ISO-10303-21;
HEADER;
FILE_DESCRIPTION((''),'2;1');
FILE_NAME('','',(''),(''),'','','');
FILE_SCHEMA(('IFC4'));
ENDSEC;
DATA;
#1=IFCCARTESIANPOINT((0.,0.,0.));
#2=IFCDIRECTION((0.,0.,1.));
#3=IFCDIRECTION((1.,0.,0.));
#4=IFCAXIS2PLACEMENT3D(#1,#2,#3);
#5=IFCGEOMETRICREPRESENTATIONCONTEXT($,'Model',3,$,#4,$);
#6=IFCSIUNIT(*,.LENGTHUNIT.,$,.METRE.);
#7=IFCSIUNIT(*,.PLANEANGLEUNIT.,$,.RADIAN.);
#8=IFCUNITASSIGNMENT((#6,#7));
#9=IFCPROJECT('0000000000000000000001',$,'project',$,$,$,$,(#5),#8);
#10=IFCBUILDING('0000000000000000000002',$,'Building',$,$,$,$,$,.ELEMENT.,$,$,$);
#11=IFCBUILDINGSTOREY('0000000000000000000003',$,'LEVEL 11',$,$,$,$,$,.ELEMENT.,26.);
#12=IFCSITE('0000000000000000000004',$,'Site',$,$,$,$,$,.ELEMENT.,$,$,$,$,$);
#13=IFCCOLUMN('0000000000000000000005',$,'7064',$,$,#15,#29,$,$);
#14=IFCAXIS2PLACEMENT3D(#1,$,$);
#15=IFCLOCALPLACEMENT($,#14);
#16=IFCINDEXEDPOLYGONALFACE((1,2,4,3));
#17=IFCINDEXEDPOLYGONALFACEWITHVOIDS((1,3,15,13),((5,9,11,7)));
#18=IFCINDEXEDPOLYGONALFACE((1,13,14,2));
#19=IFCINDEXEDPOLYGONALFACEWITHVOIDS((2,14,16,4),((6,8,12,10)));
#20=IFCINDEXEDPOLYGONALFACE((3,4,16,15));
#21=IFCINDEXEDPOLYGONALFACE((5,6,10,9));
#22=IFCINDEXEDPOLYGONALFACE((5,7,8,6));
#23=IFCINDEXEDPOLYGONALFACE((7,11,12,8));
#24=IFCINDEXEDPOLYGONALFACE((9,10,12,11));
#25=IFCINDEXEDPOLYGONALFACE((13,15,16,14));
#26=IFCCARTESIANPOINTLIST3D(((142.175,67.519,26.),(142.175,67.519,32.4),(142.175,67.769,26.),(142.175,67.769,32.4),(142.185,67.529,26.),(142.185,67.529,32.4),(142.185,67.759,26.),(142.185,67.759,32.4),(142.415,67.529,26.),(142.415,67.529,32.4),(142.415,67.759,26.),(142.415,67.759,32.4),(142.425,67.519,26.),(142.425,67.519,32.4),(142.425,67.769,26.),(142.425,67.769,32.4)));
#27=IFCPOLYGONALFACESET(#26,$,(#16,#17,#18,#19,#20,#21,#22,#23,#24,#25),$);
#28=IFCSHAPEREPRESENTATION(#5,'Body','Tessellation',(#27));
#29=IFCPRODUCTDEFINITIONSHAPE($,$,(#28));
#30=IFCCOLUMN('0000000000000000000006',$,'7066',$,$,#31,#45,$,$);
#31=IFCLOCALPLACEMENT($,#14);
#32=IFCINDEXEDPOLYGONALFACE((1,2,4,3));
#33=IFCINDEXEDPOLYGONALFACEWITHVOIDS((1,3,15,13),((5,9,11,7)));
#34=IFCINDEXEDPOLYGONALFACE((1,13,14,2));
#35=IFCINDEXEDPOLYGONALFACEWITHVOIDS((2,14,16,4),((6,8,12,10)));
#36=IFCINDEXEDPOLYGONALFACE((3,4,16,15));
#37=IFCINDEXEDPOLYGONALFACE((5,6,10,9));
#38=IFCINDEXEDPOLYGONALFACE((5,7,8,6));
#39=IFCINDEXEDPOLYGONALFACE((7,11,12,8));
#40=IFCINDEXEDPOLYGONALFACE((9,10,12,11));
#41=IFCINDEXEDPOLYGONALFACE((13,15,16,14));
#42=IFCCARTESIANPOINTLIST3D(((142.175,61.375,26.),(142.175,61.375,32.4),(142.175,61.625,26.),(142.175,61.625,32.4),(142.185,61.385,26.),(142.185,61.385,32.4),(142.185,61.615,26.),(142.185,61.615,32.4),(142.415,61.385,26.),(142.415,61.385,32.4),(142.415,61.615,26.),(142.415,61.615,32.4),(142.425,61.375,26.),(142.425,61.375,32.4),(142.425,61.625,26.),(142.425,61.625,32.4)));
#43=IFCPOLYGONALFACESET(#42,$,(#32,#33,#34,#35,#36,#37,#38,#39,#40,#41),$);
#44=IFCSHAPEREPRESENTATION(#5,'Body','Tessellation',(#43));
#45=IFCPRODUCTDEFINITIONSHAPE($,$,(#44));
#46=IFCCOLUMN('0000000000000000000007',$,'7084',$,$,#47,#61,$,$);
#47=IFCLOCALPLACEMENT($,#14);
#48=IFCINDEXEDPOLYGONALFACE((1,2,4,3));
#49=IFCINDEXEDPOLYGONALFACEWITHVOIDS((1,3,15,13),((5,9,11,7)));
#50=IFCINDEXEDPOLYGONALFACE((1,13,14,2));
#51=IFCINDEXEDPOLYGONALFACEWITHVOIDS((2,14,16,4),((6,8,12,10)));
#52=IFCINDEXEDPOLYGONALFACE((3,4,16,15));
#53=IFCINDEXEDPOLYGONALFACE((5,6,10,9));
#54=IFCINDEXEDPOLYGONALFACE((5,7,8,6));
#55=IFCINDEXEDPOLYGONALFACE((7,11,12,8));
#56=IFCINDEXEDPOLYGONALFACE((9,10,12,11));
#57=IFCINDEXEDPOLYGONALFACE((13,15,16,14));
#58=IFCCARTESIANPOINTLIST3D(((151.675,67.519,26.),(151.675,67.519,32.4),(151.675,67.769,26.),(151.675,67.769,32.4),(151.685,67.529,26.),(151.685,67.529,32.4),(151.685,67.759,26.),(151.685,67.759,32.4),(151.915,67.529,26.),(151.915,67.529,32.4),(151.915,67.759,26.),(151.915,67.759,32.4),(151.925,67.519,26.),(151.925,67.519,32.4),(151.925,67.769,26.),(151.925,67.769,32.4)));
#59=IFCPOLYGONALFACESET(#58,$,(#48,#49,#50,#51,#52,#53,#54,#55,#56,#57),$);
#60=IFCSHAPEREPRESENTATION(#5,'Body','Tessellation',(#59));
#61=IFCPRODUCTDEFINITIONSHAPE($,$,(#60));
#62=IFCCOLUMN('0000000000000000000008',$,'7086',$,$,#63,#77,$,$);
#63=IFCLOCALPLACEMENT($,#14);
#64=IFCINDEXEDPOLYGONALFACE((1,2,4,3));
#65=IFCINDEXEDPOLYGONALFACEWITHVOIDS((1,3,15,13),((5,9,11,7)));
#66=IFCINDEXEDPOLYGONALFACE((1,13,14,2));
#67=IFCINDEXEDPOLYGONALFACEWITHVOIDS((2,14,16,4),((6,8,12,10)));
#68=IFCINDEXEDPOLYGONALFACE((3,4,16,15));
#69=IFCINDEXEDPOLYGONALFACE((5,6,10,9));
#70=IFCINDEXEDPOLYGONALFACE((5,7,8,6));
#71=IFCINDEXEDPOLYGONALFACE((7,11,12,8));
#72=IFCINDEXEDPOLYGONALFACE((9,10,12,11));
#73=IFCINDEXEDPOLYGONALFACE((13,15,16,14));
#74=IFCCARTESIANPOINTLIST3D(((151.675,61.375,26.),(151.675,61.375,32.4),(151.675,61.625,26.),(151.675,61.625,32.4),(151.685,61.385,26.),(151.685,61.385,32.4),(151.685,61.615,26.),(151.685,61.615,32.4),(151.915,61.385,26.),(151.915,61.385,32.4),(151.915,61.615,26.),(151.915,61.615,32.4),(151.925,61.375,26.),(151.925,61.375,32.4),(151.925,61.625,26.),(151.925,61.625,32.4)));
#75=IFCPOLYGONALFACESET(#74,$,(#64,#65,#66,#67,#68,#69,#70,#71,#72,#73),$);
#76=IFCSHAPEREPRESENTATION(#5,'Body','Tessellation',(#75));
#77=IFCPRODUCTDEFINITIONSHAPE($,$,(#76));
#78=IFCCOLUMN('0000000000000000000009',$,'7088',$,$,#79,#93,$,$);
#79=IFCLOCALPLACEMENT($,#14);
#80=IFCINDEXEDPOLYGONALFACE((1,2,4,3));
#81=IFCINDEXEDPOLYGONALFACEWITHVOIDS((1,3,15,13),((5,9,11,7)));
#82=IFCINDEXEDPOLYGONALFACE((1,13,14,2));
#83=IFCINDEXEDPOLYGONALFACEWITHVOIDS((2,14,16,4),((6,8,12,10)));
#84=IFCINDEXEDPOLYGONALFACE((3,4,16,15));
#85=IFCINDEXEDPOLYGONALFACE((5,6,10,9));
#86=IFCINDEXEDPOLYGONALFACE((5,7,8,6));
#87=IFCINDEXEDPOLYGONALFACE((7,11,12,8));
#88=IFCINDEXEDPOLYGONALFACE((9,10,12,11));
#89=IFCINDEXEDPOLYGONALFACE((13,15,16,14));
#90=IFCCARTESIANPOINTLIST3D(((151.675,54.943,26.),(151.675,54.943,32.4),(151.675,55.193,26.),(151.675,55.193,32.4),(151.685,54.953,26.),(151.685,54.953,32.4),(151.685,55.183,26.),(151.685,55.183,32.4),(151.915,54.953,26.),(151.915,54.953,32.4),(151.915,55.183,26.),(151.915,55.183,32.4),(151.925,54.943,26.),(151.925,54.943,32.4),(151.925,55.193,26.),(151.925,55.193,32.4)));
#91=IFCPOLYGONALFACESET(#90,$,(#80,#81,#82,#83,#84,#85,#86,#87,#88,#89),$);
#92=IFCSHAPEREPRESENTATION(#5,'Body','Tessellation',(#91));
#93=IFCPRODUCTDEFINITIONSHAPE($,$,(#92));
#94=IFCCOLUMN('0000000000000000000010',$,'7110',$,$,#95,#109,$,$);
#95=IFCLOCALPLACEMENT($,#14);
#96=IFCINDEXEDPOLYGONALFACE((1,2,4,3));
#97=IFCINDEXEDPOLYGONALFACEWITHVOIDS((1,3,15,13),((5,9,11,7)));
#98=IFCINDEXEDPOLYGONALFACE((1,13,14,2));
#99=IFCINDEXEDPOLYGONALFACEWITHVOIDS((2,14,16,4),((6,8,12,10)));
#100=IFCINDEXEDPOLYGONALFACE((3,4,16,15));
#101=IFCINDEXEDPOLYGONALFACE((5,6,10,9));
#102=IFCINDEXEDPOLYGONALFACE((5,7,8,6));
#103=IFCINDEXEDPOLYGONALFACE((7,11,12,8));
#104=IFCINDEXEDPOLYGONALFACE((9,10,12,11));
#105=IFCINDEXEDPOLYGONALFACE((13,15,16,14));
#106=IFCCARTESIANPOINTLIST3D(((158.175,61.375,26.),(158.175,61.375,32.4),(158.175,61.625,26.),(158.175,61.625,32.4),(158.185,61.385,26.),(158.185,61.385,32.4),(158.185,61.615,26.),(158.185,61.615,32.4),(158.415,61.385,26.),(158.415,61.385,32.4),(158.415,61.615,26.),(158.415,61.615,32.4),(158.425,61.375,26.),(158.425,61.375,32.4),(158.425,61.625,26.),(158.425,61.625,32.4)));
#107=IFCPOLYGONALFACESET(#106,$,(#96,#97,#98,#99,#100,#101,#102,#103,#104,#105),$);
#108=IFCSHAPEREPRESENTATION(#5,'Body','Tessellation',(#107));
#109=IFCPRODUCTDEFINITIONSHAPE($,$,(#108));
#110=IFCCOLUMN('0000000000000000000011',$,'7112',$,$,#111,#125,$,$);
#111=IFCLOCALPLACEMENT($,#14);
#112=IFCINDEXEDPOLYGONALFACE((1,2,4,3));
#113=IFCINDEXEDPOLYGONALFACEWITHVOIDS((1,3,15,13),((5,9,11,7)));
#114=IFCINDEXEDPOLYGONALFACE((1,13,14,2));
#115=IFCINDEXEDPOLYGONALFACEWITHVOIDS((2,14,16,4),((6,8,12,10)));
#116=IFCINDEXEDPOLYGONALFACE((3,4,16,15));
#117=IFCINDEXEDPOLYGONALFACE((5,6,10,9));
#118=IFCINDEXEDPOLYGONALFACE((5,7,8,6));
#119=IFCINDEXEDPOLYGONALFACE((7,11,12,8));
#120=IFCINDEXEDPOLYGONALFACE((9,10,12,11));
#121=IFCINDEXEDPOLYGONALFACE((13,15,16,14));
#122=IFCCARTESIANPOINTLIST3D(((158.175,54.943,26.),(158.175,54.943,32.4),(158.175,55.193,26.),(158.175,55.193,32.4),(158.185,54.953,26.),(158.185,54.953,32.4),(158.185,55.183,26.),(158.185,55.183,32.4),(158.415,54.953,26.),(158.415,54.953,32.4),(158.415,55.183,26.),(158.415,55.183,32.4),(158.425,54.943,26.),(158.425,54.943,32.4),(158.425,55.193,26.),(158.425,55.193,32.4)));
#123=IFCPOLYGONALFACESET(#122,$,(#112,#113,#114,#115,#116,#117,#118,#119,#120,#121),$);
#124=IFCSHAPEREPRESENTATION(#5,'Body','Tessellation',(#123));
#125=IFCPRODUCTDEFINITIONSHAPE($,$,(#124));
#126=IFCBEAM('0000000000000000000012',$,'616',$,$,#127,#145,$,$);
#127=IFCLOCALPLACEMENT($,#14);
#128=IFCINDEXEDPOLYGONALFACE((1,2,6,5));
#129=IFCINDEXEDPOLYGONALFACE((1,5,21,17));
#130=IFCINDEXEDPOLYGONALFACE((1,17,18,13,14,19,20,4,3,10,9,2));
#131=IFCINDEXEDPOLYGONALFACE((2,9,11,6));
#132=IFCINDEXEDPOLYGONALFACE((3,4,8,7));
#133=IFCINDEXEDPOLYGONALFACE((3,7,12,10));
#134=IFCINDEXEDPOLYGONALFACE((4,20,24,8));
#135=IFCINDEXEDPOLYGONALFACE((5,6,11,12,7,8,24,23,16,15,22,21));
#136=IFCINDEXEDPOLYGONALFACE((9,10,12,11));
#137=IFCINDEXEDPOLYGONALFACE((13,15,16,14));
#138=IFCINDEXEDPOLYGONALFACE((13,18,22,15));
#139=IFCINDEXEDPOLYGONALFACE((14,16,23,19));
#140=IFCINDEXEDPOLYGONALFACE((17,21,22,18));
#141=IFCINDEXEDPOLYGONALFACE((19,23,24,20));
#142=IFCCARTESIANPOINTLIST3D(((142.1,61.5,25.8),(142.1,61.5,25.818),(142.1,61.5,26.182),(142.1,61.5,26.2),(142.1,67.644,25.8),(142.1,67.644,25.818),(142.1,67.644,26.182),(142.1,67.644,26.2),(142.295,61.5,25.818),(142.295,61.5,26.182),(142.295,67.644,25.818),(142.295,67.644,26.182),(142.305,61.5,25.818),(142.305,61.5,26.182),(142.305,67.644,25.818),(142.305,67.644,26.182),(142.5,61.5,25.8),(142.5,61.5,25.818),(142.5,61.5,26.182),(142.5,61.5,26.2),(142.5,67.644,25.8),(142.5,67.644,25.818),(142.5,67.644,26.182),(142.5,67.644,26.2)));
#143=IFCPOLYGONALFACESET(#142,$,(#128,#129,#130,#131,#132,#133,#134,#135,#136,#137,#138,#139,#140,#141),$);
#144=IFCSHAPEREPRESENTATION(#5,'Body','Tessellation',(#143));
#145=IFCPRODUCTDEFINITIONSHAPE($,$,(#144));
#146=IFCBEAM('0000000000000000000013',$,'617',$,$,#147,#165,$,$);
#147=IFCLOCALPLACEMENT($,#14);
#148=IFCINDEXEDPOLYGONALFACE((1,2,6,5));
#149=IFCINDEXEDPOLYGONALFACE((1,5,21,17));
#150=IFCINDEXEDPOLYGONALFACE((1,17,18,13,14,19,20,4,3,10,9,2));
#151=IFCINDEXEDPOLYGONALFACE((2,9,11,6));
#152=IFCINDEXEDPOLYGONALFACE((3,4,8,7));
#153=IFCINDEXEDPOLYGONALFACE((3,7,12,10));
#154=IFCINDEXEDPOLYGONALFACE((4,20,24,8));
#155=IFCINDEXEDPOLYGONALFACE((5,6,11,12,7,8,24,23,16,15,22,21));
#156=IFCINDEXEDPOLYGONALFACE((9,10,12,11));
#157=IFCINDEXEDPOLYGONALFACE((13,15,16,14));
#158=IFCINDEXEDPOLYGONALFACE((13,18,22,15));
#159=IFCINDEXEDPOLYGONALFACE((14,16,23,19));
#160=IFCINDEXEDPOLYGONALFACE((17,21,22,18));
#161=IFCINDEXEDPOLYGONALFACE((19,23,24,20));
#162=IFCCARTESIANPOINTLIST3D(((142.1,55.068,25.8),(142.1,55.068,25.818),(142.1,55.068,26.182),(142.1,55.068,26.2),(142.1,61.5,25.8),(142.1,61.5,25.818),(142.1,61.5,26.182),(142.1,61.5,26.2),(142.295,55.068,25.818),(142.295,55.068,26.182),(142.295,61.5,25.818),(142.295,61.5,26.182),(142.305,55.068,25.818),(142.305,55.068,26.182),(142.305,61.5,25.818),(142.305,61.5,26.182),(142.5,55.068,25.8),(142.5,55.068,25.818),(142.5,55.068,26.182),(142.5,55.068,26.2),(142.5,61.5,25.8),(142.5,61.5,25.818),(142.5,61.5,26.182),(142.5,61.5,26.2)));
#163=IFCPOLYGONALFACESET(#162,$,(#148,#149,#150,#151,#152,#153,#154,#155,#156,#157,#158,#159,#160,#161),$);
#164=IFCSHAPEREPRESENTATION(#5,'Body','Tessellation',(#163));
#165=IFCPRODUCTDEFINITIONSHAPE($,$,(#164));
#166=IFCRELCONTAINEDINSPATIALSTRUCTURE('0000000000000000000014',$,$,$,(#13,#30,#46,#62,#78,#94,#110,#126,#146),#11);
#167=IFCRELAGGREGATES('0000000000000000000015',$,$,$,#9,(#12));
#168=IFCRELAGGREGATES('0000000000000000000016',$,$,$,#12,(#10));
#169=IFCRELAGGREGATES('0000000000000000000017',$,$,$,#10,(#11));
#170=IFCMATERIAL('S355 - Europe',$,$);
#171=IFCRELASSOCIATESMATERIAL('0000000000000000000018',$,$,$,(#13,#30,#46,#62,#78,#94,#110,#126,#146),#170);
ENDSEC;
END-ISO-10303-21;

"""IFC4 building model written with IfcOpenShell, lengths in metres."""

from ifc_helpers import new_model, si_unit, frame, origin_with_axes, origin_2d_with_axis, place, context, project, spatial, hollow_rectangle, i_section, extrude, material, material_profile, profile_set, profile_usage, element, save


model = new_model("IFC4")

# Units and contexts
model_context = context("Model", 3, world=origin_with_axes())
ifc_project = project(units=[si_unit("LENGTHUNIT", "METRE"), si_unit("PLANEANGLEUNIT", "RADIAN")], contexts=[model_context])

# Site, building, storey
site = spatial("IfcSite", under=ifc_project, Name="Site", CompositionType="ELEMENT")
building = spatial("IfcBuilding", under=site, Name="Building", CompositionType="ELEMENT")
storey = spatial("IfcBuildingStorey", under=building, Name="LEVEL 11", CompositionType="ELEMENT", Elevation=26.0)

# Columns
ifc_material = material(Name="S355 - Europe")
ifc_material_profile_1 = material_profile(ifc_material, hollow_rectangle(XDim=0.25, YDim=0.25, WallThickness=0.01, at=origin_2d_with_axis()))
ifc_profile_set_1 = profile_set([ifc_material_profile_1])
ifc_profile_usage_1 = profile_usage(ifc_profile_set_1, cardinal=10)
column_1_placement = place(None, frame((142.3, 67.644, 26.0), z_axis=(0.0, 0.0, 1.0), x_axis=(0.0, -1.0, 0.0)))
element("IfcColumn", 1, at=column_1_placement, inside=storey, material=ifc_profile_usage_1, Name="7064", context=model_context, shape_type="SweptSolid", body=[
    extrude(hollow_rectangle(XDim=0.25, YDim=0.25, WallThickness=0.01, at=origin_2d_with_axis()), origin_with_axes(), (0.0, 0.0, 1.0), 6.4),
])
ifc_material_profile_2 = material_profile(ifc_material, hollow_rectangle(XDim=0.25, YDim=0.25, WallThickness=0.01, at=origin_2d_with_axis()))
ifc_profile_set_2 = profile_set([ifc_material_profile_2])
ifc_profile_usage_2 = profile_usage(ifc_profile_set_2, cardinal=10)
column_2_placement = place(None, frame((142.3, 61.5, 26.0), z_axis=(0.0, 0.0, 1.0), x_axis=(0.0, -1.0, 0.0)))
element("IfcColumn", 2, at=column_2_placement, inside=storey, material=ifc_profile_usage_2, Name="7066", context=model_context, shape_type="SweptSolid", body=[
    extrude(hollow_rectangle(XDim=0.25, YDim=0.25, WallThickness=0.01, at=origin_2d_with_axis()), origin_with_axes(), (0.0, 0.0, 1.0), 6.4),
])
ifc_material_profile_3 = material_profile(ifc_material, hollow_rectangle(XDim=0.25, YDim=0.25, WallThickness=0.01, at=origin_2d_with_axis()))
ifc_profile_set_3 = profile_set([ifc_material_profile_3])
ifc_profile_usage_3 = profile_usage(ifc_profile_set_3, cardinal=10)
column_3_placement = place(None, frame((151.8, 67.644, 26.0), z_axis=(0.0, 0.0, 1.0), x_axis=(0.0, -1.0, 0.0)))
element("IfcColumn", 3, at=column_3_placement, inside=storey, material=ifc_profile_usage_3, Name="7084", context=model_context, shape_type="SweptSolid", body=[
    extrude(hollow_rectangle(XDim=0.25, YDim=0.25, WallThickness=0.01, at=origin_2d_with_axis()), origin_with_axes(), (0.0, 0.0, 1.0), 6.4),
])
ifc_material_profile_4 = material_profile(ifc_material, hollow_rectangle(XDim=0.25, YDim=0.25, WallThickness=0.01, at=origin_2d_with_axis()))
ifc_profile_set_4 = profile_set([ifc_material_profile_4])
ifc_profile_usage_4 = profile_usage(ifc_profile_set_4, cardinal=10)
column_4_placement = place(None, frame((151.8, 61.5, 26.0), z_axis=(0.0, 0.0, 1.0), x_axis=(0.0, -1.0, 0.0)))
element("IfcColumn", 4, at=column_4_placement, inside=storey, material=ifc_profile_usage_4, Name="7086", context=model_context, shape_type="SweptSolid", body=[
    extrude(hollow_rectangle(XDim=0.25, YDim=0.25, WallThickness=0.01, at=origin_2d_with_axis()), origin_with_axes(), (0.0, 0.0, 1.0), 6.4),
])
ifc_material_profile_5 = material_profile(ifc_material, hollow_rectangle(XDim=0.25, YDim=0.25, WallThickness=0.01, at=origin_2d_with_axis()))
ifc_profile_set_5 = profile_set([ifc_material_profile_5])
ifc_profile_usage_5 = profile_usage(ifc_profile_set_5, cardinal=10)
column_5_placement = place(None, frame((151.8, 55.068, 26.0), z_axis=(0.0, 0.0, 1.0), x_axis=(0.0, -1.0, 0.0)))
element("IfcColumn", 5, at=column_5_placement, inside=storey, material=ifc_profile_usage_5, Name="7088", context=model_context, shape_type="SweptSolid", body=[
    extrude(hollow_rectangle(XDim=0.25, YDim=0.25, WallThickness=0.01, at=origin_2d_with_axis()), origin_with_axes(), (0.0, 0.0, 1.0), 6.4),
])
ifc_material_profile_6 = material_profile(ifc_material, hollow_rectangle(XDim=0.25, YDim=0.25, WallThickness=0.01, at=origin_2d_with_axis()))
ifc_profile_set_6 = profile_set([ifc_material_profile_6])
ifc_profile_usage_6 = profile_usage(ifc_profile_set_6, cardinal=10)
column_6_placement = place(None, frame((158.3, 61.5, 26.0), z_axis=(0.0, 0.0, 1.0), x_axis=(0.0, -1.0, 0.0)))
element("IfcColumn", 6, at=column_6_placement, inside=storey, material=ifc_profile_usage_6, Name="7110", context=model_context, shape_type="SweptSolid", body=[
    extrude(hollow_rectangle(XDim=0.25, YDim=0.25, WallThickness=0.01, at=origin_2d_with_axis()), origin_with_axes(), (0.0, 0.0, 1.0), 6.4),
])
ifc_material_profile_7 = material_profile(ifc_material, hollow_rectangle(XDim=0.25, YDim=0.25, WallThickness=0.01, at=origin_2d_with_axis()))
ifc_profile_set_7 = profile_set([ifc_material_profile_7])
ifc_profile_usage_7 = profile_usage(ifc_profile_set_7, cardinal=10)
column_7_placement = place(None, frame((158.3, 55.068, 26.0), z_axis=(0.0, 0.0, 1.0), x_axis=(0.0, -1.0, 0.0)))
element("IfcColumn", 7, at=column_7_placement, inside=storey, material=ifc_profile_usage_7, Name="7112", context=model_context, shape_type="SweptSolid", body=[
    extrude(hollow_rectangle(XDim=0.25, YDim=0.25, WallThickness=0.01, at=origin_2d_with_axis()), origin_with_axes(), (0.0, 0.0, 1.0), 6.4),
])

# Beams
ifc_material_profile_8 = material_profile(ifc_material, i_section(OverallWidth=0.4, OverallDepth=0.4, WebThickness=0.01, FlangeThickness=0.018, at=origin_2d_with_axis()))
ifc_profile_set_8 = profile_set([ifc_material_profile_8])
ifc_profile_usage_8 = profile_usage(ifc_profile_set_8, cardinal=10)
beam_1_placement = place(None, frame((142.3, 67.644, 26.0), z_axis=(0.0, -1.0, 0.0), x_axis=(1.0, 0.0, 0.0)))
element("IfcBeam", 8, at=beam_1_placement, inside=storey, material=ifc_profile_usage_8, Name="616", context=model_context, shape_type="SweptSolid", body=[
    extrude(i_section(OverallWidth=0.4, OverallDepth=0.4, WebThickness=0.01, FlangeThickness=0.018, at=origin_2d_with_axis()), origin_with_axes(), (0.0, 0.0, 1.0), 6.144),
])
ifc_material_profile_9 = material_profile(ifc_material, i_section(OverallWidth=0.4, OverallDepth=0.4, WebThickness=0.01, FlangeThickness=0.018, at=origin_2d_with_axis()))
ifc_profile_set_9 = profile_set([ifc_material_profile_9])
ifc_profile_usage_9 = profile_usage(ifc_profile_set_9, cardinal=10)
beam_2_placement = place(None, frame((142.3, 61.5, 26.0), z_axis=(0.0, -1.0, 0.0), x_axis=(1.0, 0.0, 0.0)))
element("IfcBeam", 9, at=beam_2_placement, inside=storey, material=ifc_profile_usage_9, Name="617", context=model_context, shape_type="SweptSolid", body=[
    extrude(i_section(OverallWidth=0.4, OverallDepth=0.4, WebThickness=0.01, FlangeThickness=0.018, at=origin_2d_with_axis()), origin_with_axes(), (0.0, 0.0, 1.0), 6.432),
])

save(model, "model.ifc")
